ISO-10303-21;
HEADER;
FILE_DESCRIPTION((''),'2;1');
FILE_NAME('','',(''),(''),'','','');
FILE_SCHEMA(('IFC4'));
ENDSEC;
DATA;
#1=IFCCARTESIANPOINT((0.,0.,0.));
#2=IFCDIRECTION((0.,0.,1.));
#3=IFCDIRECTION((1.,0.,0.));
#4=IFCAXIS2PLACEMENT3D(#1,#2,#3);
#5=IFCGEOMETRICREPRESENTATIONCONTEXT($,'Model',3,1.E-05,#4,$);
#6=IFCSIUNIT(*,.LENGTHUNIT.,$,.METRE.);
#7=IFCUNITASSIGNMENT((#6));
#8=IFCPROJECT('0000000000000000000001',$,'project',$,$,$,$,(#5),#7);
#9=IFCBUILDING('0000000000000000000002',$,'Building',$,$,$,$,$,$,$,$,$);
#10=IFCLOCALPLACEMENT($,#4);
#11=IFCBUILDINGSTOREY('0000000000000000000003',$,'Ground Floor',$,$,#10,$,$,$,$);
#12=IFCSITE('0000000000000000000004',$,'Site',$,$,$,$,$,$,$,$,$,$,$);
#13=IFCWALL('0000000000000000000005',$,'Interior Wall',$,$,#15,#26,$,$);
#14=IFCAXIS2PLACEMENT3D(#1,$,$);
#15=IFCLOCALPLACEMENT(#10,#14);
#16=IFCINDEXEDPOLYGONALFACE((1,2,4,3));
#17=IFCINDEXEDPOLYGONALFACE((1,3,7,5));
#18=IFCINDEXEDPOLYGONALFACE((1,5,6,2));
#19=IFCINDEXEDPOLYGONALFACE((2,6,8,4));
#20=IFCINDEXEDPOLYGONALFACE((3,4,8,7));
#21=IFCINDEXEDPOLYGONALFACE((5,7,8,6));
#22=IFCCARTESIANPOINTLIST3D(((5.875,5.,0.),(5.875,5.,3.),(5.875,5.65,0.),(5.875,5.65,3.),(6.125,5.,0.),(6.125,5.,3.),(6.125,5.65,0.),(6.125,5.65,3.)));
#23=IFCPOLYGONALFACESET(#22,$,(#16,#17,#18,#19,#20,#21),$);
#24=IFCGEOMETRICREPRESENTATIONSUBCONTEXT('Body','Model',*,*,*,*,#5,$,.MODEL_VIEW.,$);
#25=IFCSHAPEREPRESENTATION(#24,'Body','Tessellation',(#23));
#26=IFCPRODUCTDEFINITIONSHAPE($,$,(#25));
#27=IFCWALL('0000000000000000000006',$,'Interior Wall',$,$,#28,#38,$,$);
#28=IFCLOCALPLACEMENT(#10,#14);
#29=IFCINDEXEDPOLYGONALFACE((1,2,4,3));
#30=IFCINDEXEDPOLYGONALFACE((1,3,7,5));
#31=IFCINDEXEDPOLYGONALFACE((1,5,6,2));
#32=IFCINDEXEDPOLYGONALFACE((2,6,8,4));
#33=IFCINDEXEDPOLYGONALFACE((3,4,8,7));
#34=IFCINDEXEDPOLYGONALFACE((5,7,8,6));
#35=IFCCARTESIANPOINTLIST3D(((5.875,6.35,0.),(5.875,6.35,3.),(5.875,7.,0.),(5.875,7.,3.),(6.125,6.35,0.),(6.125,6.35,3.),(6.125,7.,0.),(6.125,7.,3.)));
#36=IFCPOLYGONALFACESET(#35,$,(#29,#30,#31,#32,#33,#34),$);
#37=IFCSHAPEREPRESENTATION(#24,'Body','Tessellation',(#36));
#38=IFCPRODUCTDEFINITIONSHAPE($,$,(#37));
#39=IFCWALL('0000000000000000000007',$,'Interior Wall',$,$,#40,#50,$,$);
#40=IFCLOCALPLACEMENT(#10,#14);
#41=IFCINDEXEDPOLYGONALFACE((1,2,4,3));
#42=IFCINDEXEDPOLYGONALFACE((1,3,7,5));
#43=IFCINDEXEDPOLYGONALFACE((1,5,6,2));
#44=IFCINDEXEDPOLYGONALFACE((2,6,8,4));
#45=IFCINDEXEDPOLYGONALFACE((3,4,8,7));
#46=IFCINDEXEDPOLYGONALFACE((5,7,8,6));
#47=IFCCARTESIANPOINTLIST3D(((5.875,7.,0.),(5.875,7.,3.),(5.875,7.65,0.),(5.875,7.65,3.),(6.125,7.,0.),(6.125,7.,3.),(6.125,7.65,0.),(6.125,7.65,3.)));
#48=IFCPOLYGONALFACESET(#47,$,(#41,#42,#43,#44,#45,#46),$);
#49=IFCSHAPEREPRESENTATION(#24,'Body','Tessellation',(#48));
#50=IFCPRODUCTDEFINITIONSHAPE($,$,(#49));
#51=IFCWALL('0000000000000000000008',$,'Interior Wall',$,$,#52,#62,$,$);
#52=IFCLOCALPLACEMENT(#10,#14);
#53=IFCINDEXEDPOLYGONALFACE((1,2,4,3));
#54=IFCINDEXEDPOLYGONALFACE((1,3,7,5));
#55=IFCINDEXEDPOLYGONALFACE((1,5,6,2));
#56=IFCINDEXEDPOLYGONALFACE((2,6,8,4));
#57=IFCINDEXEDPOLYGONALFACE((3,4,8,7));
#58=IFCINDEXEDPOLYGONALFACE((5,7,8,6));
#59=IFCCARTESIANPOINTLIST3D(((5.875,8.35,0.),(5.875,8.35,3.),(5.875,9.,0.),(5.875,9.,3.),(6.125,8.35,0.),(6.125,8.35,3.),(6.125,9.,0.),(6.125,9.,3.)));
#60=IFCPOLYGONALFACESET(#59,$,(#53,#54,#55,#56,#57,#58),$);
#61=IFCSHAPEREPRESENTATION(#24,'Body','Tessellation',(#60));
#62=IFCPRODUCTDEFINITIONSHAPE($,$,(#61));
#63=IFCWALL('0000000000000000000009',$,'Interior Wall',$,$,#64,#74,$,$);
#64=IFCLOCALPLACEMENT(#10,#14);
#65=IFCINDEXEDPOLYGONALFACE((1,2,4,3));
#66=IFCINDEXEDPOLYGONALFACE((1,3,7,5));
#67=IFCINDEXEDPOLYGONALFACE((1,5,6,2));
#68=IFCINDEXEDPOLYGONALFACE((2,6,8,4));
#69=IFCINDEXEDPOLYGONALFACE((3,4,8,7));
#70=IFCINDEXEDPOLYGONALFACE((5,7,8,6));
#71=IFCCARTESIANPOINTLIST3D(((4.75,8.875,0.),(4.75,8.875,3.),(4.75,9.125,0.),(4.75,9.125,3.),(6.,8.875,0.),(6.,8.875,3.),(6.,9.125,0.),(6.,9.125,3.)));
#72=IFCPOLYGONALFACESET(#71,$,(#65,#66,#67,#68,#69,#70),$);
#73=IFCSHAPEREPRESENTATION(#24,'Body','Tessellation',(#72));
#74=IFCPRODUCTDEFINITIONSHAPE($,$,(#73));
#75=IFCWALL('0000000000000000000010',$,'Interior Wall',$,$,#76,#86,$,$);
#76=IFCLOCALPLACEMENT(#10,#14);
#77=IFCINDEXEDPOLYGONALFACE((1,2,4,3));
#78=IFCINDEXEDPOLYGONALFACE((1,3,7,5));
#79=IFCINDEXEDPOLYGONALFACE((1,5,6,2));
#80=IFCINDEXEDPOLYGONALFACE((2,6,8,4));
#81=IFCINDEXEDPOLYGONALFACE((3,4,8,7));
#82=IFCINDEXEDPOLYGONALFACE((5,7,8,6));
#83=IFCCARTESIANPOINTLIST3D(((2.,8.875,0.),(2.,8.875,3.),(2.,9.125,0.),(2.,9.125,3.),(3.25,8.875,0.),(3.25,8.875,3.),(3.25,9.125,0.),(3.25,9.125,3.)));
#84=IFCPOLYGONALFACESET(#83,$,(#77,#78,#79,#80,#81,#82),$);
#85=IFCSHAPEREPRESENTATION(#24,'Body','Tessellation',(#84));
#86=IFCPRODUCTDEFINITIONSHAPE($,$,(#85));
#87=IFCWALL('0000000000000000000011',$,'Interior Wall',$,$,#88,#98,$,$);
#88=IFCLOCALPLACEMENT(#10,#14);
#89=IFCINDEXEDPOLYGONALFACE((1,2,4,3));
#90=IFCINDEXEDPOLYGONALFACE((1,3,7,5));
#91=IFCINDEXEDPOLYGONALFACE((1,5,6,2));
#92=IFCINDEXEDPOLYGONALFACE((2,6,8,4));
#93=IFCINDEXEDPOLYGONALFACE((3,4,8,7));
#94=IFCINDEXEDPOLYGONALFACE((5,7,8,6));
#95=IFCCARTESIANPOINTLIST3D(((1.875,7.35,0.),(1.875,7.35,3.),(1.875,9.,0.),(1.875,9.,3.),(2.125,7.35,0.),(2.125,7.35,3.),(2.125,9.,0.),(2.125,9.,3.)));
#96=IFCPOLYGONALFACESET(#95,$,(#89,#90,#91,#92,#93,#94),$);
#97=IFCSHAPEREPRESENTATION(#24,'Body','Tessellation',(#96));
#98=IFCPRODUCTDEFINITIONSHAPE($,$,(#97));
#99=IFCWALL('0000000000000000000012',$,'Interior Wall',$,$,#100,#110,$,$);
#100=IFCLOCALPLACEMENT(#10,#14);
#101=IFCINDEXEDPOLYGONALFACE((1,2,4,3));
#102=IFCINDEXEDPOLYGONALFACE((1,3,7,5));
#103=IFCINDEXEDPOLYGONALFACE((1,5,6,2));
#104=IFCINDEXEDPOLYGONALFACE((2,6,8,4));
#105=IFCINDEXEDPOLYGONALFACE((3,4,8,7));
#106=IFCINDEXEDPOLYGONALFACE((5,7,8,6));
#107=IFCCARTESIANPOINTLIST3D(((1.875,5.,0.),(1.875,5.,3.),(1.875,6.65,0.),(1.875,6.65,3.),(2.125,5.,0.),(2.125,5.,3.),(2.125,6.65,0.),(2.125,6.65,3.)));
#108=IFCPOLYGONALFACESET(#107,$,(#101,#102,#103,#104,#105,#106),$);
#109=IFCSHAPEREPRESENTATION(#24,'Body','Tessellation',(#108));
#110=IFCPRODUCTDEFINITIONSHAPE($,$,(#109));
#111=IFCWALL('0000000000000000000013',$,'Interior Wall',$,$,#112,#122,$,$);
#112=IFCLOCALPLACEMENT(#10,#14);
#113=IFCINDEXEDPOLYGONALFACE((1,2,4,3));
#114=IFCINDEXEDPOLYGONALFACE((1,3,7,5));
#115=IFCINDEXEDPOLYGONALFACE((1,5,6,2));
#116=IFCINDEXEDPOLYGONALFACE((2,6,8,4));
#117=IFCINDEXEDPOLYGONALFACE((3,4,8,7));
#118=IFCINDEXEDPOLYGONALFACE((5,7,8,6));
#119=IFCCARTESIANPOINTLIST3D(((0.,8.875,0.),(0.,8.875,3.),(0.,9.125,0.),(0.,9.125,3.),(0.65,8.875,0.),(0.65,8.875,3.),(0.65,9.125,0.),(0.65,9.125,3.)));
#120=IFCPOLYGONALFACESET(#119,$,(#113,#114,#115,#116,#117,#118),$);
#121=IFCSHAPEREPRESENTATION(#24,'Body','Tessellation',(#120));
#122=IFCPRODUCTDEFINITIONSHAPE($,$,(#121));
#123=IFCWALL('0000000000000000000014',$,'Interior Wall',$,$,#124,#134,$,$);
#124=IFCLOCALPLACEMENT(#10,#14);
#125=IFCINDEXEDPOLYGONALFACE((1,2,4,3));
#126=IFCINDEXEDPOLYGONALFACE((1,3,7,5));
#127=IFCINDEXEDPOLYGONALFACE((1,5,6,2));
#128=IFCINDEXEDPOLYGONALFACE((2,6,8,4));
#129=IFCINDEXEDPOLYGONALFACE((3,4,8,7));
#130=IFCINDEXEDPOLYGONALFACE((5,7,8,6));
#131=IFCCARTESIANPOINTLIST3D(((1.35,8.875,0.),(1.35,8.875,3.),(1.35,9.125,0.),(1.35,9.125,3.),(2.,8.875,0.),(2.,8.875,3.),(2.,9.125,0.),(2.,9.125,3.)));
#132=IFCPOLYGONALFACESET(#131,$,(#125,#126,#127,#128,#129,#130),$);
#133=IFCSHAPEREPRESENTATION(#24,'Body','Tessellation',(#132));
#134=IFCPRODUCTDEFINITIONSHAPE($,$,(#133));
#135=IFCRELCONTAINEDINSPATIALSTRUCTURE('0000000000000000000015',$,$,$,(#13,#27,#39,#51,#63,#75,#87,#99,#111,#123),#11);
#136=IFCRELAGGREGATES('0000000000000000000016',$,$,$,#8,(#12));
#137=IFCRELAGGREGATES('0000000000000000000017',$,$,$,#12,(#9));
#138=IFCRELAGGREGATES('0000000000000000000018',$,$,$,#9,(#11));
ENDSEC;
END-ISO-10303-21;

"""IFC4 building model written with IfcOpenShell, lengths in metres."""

from ifc_helpers import new_model, si_unit, frame, origin_with_axes, place, context, subcontext, project, spatial, indexed_curve, outline, extrude, element, save


model = new_model("IFC4")

# Units and contexts
model_context = context("Model", 3, precision=1e-05, world=origin_with_axes())
body_context = subcontext(model_context, "Body", "Model", "MODEL_VIEW")
ifc_project = project(units=[si_unit("LENGTHUNIT", "METRE")], contexts=[model_context])

# Site, building, storey
site = spatial("IfcSite", under=ifc_project, Name="Site")
building = spatial("IfcBuilding", under=site, Name="Building")
storey_placement = place(None, origin_with_axes())
storey = spatial("IfcBuildingStorey", under=building, at=storey_placement, Name="Ground Floor")

# Walls
for number, where, z_axis, x_axis, name in (
    (1, (6.0, 5.0, 0.0), (0.0, 0.0, 1.0), (0.0, 1.0, 0.0), "Interior Wall"),
    (2, (6.0, 6.35, 0.0), (0.0, 0.0, 1.0), (0.0, 1.0, 0.0), "Interior Wall"),
    (3, (6.0, 7.0, 0.0), (0.0, 0.0, 1.0), (0.0, 1.0, 0.0), "Interior Wall"),
    (4, (6.0, 8.35, 0.0), (0.0, 0.0, 1.0), (0.0, 1.0, 0.0), "Interior Wall"),
):
    element("IfcWall", number, at=place(storey_placement, frame(where, z_axis=z_axis, x_axis=x_axis)), inside=storey, Name=name, context=body_context, shape_type="SweptSolid", body=[
        extrude(outline(indexed_curve([(0.0, 0.0), (0.0, 0.25), (0.65, 0.25), (0.65, 0.0), (0.0, 0.0)], self_intersect=False)), frame((0.0, -0.125, 0.0), z_axis=(0.0, 0.0, 1.0), x_axis=(1.0, 0.0, 0.0)), (0.0, 0.0, 1.0), 3.0),
    ])
for number, where, z_axis, x_axis, name in (
    (5, (6.0, 9.0, 0.0), (0.0, 0.0, 1.0), (-1.0, 0.0, 0.0), "Interior Wall"),
    (6, (3.25, 9.0, 0.0), (0.0, 0.0, 1.0), (-1.0, 0.0, 0.0), "Interior Wall"),
):
    element("IfcWall", number, at=place(storey_placement, frame(where, z_axis=z_axis, x_axis=x_axis)), inside=storey, Name=name, context=body_context, shape_type="SweptSolid", body=[
        extrude(outline(indexed_curve([(0.0, 0.0), (0.0, 0.25), (1.25, 0.25), (1.25, 0.0), (0.0, 0.0)], self_intersect=False)), frame((0.0, -0.125, 0.0), z_axis=(0.0, 0.0, 1.0), x_axis=(1.0, 0.0, 0.0)), (0.0, 0.0, 1.0), 3.0),
    ])
for number, where, z_axis, x_axis, name in (
    (7, (2.0, 9.0, 0.0), (0.0, 0.0, 1.0), (0.0, -1.0, 0.0), "Interior Wall"),
    (8, (2.0, 6.65, 0.0), (0.0, 0.0, 1.0), (0.0, -1.0, 0.0), "Interior Wall"),
):
    element("IfcWall", number, at=place(storey_placement, frame(where, z_axis=z_axis, x_axis=x_axis)), inside=storey, Name=name, context=body_context, shape_type="SweptSolid", body=[
        extrude(outline(indexed_curve([(0.0, 0.0), (0.0, 0.25), (1.65, 0.25), (1.65, 0.0), (0.0, 0.0)], self_intersect=False)), frame((0.0, -0.125, 0.0), z_axis=(0.0, 0.0, 1.0), x_axis=(1.0, 0.0, 0.0)), (0.0, 0.0, 1.0), 3.0),
    ])
wall_1_placement = place(storey_placement, frame((0.0, 9.0, 0.0), z_axis=(0.0, 0.0, 1.0), x_axis=(1.0, 0.0, 0.0)))
element("IfcWall", 9, at=wall_1_placement, inside=storey, Name="Interior Wall", context=body_context, shape_type="SweptSolid", body=[
    extrude(outline(indexed_curve([(0.0, 0.0), (0.0, 0.25), (0.65, 0.25), (0.65, 0.0), (0.0, 0.0)], self_intersect=False)), frame((0.0, -0.125, 0.0), z_axis=(0.0, 0.0, 1.0), x_axis=(1.0, 0.0, 0.0)), (0.0, 0.0, 1.0), 3.0),
])
wall_2_placement = place(storey_placement, frame((1.35, 9.0, 0.0), z_axis=(0.0, 0.0, 1.0), x_axis=(1.0, 0.0, 0.0)))
element("IfcWall", 10, at=wall_2_placement, inside=storey, Name="Interior Wall", context=body_context, shape_type="SweptSolid", body=[
    extrude(outline(indexed_curve([(0.0, 0.0), (0.0, 0.25), (0.65, 0.25), (0.65, 0.0), (0.0, 0.0)], self_intersect=False)), frame((0.0, -0.125, 0.0), z_axis=(0.0, 0.0, 1.0), x_axis=(1.0, 0.0, 0.0)), (0.0, 0.0, 1.0), 3.0),
])

save(model, "model.ifc")
